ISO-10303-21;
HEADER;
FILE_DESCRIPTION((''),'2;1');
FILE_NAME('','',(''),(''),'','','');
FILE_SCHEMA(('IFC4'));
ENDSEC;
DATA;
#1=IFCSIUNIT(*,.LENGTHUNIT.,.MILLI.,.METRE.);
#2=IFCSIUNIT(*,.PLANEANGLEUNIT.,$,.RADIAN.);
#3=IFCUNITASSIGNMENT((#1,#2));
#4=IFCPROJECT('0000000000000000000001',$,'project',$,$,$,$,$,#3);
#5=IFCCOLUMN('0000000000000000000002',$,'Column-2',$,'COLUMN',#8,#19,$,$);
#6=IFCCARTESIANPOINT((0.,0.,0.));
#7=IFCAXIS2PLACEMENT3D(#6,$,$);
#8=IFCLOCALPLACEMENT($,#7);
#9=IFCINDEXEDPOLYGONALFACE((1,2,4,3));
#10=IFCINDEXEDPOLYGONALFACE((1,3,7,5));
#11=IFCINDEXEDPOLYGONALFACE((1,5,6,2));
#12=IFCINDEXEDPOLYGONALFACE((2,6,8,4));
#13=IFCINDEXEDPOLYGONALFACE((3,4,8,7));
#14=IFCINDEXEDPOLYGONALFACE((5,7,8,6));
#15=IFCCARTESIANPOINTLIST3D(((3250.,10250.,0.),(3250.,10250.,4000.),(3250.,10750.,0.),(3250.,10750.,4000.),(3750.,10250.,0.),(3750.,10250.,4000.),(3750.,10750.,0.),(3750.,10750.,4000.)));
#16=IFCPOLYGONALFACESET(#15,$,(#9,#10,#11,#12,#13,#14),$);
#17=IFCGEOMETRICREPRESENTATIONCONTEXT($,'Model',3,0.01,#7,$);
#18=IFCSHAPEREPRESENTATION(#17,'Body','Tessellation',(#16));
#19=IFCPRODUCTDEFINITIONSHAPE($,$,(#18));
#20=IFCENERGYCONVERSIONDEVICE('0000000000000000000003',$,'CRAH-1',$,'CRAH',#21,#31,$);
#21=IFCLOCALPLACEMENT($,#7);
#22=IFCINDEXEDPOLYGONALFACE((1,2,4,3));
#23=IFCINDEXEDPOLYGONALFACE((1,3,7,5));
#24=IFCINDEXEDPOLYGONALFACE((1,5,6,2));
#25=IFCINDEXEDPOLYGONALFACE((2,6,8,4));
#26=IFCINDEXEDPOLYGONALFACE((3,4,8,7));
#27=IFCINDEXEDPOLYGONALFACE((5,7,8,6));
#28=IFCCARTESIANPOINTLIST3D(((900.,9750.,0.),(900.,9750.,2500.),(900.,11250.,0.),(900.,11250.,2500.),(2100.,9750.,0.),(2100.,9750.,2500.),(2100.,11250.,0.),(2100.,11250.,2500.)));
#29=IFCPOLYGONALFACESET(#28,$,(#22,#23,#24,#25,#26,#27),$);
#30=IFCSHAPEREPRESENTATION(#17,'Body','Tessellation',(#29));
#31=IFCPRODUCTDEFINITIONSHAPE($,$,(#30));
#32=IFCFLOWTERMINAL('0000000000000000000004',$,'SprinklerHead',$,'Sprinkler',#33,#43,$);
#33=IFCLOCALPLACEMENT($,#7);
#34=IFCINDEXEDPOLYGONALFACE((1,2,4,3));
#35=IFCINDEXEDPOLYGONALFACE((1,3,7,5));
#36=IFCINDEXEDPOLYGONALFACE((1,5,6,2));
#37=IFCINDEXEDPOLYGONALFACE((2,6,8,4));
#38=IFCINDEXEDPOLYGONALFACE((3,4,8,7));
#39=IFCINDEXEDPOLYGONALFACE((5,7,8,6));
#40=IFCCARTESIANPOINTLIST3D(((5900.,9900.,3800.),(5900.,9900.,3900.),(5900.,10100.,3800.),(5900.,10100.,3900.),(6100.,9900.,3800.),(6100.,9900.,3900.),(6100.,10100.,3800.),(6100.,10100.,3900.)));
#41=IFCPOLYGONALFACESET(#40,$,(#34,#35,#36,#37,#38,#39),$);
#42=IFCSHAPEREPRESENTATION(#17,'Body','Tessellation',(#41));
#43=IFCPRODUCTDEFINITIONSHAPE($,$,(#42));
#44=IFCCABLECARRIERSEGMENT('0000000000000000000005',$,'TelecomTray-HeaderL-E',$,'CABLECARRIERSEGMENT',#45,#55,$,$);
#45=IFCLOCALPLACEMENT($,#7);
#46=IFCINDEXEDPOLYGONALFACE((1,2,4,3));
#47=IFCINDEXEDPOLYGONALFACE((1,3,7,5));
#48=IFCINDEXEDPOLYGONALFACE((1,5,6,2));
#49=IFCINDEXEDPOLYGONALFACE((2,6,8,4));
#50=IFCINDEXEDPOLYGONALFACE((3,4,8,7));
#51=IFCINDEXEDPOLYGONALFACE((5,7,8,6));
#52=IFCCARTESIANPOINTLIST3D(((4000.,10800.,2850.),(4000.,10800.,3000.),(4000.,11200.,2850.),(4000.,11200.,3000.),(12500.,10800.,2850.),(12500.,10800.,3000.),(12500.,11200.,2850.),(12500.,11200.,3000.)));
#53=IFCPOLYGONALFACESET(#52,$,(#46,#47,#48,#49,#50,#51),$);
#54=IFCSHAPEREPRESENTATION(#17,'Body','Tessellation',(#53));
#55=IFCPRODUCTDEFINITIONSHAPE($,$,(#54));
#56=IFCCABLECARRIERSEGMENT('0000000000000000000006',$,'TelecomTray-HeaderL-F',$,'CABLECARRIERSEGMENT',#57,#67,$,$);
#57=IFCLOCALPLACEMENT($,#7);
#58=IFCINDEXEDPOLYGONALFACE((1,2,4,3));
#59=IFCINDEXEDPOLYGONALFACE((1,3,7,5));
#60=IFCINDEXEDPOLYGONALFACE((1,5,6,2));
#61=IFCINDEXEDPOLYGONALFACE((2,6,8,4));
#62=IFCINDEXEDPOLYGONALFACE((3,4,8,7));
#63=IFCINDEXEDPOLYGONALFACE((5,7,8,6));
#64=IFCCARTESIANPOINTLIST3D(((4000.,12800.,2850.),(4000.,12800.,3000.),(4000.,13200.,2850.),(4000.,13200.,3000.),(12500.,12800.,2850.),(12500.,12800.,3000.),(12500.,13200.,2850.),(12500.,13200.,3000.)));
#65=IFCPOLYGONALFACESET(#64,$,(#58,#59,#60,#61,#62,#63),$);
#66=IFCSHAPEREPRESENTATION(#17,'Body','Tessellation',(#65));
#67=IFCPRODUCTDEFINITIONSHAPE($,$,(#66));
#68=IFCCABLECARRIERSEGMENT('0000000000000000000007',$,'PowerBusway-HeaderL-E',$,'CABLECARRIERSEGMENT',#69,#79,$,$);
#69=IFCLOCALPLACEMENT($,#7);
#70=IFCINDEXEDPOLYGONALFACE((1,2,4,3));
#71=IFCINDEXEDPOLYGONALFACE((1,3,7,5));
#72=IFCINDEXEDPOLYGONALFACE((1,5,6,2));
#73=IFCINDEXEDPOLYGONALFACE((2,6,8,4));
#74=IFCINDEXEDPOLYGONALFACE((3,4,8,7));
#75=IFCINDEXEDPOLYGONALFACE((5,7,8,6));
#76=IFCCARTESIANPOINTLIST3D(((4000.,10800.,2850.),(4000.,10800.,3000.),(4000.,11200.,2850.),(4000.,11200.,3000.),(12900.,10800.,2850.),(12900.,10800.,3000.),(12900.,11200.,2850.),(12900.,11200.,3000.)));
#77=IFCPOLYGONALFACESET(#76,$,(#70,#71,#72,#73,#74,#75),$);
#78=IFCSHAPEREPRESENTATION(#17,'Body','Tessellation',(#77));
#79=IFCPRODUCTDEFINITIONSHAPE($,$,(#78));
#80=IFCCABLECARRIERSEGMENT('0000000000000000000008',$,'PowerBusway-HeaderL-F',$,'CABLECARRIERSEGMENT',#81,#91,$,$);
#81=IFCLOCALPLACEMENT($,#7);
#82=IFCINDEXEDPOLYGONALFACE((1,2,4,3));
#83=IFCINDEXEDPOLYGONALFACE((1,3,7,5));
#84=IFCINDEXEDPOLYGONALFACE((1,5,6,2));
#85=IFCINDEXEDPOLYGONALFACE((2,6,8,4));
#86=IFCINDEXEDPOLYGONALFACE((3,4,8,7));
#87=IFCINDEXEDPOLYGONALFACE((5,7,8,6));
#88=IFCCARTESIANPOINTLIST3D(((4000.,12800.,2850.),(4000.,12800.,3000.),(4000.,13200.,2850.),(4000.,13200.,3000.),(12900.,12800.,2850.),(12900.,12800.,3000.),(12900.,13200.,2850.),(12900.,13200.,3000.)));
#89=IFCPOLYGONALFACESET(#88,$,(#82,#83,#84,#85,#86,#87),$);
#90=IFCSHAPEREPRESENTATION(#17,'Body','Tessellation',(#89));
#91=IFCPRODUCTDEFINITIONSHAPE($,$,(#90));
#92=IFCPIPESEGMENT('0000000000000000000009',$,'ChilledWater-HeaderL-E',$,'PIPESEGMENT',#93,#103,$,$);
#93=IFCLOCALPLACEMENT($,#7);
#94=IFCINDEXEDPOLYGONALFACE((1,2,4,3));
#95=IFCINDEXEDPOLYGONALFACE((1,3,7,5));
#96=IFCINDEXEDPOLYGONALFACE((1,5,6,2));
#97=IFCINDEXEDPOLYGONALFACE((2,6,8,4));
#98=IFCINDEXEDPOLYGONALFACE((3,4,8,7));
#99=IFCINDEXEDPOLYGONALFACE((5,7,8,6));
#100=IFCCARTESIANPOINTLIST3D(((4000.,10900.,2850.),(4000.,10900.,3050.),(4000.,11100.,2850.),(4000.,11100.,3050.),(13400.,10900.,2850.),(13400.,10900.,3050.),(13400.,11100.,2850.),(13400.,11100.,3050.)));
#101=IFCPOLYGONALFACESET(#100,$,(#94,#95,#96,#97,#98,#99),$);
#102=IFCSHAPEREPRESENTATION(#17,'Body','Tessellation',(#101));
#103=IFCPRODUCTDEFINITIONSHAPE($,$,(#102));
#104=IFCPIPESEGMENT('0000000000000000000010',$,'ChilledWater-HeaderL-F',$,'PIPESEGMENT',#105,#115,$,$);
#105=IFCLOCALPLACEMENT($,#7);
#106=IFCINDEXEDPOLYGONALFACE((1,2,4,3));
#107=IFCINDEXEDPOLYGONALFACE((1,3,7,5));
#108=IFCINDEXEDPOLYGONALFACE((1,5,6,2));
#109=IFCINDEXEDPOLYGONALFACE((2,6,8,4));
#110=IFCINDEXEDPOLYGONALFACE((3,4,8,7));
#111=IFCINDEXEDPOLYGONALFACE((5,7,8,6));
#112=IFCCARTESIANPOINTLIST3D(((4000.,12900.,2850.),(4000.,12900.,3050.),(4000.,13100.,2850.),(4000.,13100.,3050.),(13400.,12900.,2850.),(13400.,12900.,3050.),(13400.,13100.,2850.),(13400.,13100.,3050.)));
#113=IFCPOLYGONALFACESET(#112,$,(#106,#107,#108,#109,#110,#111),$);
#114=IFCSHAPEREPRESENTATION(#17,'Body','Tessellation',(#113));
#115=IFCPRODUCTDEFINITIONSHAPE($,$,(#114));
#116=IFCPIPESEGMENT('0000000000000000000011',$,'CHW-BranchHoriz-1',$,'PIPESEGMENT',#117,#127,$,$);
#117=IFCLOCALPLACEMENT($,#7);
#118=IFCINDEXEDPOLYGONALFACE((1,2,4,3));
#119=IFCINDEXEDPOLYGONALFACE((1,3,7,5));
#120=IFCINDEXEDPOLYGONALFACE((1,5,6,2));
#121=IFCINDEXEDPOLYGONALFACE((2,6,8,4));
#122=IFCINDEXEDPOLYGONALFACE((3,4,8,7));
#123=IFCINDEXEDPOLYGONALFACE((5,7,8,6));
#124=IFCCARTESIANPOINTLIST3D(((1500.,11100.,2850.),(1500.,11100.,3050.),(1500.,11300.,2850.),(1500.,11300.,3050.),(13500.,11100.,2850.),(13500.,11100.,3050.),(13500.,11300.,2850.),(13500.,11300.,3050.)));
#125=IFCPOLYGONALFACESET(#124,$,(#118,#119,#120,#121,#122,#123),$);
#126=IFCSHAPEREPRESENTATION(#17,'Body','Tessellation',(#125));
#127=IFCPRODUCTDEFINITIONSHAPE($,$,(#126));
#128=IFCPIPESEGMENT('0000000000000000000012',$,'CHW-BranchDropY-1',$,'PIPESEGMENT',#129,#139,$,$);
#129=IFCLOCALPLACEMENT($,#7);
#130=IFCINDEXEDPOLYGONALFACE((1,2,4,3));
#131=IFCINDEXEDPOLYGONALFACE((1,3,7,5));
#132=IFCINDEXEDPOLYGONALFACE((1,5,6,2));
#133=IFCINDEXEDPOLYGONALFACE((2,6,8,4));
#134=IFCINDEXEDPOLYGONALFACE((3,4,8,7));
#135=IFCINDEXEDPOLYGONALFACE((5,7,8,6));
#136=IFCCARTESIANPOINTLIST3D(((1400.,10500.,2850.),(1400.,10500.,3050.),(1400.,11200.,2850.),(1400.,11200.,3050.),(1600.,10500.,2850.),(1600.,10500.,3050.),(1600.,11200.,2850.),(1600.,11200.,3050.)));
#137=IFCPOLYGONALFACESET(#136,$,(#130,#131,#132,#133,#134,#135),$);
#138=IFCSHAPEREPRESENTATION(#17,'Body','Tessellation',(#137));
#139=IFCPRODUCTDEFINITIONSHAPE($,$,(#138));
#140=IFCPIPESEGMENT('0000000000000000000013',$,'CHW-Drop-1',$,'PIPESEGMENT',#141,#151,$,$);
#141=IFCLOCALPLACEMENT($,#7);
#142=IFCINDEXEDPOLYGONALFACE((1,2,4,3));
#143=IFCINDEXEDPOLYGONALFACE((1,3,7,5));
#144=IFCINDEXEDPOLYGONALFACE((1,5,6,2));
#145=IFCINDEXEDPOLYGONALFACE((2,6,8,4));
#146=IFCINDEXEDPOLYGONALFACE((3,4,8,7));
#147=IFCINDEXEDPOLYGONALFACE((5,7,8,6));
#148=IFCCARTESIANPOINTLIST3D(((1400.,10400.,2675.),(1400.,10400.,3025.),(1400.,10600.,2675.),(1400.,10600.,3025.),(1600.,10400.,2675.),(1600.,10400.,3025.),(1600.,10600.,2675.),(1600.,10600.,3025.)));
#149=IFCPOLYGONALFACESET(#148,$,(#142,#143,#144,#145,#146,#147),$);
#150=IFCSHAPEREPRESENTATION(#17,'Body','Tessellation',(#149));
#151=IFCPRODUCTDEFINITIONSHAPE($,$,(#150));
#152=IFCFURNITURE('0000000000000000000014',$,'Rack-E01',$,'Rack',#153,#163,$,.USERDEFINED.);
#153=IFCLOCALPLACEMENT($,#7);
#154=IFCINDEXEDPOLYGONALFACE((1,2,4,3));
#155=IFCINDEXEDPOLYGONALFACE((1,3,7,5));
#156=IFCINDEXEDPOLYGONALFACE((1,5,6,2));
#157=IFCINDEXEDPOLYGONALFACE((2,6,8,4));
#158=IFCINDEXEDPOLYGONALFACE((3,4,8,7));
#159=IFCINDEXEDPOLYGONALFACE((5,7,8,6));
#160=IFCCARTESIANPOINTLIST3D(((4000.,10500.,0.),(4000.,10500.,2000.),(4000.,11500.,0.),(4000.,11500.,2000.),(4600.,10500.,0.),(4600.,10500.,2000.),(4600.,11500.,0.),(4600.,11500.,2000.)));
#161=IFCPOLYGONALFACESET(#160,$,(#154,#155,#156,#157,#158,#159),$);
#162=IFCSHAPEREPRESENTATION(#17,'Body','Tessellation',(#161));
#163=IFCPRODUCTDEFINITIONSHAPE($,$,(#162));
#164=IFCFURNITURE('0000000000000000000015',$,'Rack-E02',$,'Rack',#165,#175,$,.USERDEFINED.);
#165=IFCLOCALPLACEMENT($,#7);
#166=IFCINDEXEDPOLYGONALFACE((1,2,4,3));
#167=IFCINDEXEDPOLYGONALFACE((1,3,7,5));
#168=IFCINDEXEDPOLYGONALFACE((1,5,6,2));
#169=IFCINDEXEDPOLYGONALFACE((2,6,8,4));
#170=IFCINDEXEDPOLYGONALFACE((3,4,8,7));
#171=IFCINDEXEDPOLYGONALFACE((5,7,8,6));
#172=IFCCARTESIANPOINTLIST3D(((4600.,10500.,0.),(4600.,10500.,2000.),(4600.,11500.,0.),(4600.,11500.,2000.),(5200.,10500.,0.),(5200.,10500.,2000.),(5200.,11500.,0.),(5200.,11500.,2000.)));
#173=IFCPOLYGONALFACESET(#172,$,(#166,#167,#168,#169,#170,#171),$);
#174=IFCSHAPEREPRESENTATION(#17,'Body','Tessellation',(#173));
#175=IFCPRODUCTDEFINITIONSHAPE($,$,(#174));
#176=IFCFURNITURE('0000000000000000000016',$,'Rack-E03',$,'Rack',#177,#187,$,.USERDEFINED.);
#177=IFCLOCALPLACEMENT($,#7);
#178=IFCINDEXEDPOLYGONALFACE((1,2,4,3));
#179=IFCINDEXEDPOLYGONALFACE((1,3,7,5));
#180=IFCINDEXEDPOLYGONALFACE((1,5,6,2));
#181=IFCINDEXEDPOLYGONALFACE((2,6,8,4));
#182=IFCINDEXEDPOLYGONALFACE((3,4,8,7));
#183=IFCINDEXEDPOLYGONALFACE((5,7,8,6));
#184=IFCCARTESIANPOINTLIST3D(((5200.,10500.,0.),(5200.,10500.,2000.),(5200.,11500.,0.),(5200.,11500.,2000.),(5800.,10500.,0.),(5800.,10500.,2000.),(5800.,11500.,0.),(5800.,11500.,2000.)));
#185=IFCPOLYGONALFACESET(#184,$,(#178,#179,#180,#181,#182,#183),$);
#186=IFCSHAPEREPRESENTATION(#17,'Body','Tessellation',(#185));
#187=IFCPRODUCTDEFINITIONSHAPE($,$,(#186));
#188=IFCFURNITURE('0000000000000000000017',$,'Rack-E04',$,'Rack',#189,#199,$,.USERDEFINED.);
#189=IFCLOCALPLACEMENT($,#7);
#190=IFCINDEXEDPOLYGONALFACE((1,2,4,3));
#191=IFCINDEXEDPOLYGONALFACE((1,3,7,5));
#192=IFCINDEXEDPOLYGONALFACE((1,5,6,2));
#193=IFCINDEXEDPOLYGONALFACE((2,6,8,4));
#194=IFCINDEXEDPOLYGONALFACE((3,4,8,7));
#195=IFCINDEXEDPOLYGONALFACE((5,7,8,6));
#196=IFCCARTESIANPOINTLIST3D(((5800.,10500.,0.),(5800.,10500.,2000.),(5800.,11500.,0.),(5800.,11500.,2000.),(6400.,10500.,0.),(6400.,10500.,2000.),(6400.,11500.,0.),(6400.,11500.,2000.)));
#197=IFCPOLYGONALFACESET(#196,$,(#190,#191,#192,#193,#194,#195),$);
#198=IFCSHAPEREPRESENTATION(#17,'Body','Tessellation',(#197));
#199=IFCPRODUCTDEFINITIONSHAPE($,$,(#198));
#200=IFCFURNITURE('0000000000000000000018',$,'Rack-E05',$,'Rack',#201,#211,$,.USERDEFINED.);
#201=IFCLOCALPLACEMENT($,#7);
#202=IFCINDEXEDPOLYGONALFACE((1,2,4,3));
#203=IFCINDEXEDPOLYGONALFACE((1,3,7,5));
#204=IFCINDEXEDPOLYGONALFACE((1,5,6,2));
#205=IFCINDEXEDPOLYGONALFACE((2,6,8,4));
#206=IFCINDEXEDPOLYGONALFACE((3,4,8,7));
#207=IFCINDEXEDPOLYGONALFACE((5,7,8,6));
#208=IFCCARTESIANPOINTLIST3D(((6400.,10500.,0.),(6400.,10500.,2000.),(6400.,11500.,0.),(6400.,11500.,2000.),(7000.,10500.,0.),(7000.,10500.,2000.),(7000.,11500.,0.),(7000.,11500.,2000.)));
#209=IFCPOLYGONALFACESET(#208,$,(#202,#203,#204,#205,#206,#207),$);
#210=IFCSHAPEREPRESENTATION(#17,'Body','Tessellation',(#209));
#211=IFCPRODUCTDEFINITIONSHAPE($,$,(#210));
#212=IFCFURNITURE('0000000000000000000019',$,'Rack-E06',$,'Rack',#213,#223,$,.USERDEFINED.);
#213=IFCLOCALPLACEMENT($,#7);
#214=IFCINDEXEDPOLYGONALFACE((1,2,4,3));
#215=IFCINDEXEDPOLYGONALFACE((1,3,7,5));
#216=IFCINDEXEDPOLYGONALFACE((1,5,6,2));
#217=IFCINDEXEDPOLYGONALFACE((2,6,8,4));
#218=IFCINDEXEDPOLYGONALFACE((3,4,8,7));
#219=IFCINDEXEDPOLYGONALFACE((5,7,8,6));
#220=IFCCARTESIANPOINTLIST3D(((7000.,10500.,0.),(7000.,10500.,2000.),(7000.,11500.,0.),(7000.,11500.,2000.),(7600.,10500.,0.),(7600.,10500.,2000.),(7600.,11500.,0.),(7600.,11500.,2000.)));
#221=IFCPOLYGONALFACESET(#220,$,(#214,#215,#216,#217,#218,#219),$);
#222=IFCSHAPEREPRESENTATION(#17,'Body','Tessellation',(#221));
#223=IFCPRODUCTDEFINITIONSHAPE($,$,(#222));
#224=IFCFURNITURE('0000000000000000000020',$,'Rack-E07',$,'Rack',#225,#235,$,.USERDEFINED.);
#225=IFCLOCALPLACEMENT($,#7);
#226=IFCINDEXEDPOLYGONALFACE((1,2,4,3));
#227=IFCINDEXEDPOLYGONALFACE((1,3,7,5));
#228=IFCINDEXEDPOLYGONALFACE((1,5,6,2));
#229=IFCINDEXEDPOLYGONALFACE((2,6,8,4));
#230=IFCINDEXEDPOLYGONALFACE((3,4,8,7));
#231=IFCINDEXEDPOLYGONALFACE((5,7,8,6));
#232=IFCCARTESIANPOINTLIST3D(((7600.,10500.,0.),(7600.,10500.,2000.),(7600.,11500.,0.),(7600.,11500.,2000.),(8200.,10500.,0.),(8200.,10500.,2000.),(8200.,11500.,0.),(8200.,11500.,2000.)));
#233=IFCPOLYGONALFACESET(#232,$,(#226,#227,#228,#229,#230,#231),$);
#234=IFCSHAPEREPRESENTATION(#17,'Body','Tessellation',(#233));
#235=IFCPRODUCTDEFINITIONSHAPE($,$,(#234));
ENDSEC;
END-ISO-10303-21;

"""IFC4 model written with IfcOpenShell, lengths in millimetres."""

from ifc_helpers import new_model, si_unit, frame, origin, place, context, project, polyline, outline, extrude, element, save


model = new_model("IFC4")

# Units and contexts
model_context = context("Model", 3, precision=0.01, world=origin())
ifc_project = project(units=[si_unit("LENGTHUNIT", "METRE", prefix="MILLI"), si_unit("PLANEANGLEUNIT", "RADIAN")])

# Column
column_placement = place(None, frame((3500.0, 10500.0, 0.0)))
element("IfcColumn", 1, at=column_placement, Name="Column-2", ObjectType="COLUMN", context=model_context, shape_type="SweptSolid", body=[
    extrude(outline(polyline([(-250.0, -250.0), (250.0, -250.0), (250.0, 250.0), (-250.0, 250.0), (-250.0, -250.0)])), origin(), (0.0, 0.0, 1.0), 4000.0),
])

# Energy conversion device
energy_conversion_device_placement = place(None, frame((1500.0, 10500.0, 0.0)))
element("IfcEnergyConversionDevice", 2, at=energy_conversion_device_placement, Name="CRAH-1", ObjectType="CRAH", context=model_context, shape_type="SweptSolid", body=[
    extrude(outline(polyline([(-600.0, -750.0), (600.0, -750.0), (600.0, 750.0), (-600.0, 750.0), (-600.0, -750.0)])), origin(), (0.0, 0.0, 1.0), 2500.0),
])

# Flow terminal
flow_terminal_placement = place(None, frame((6000.0, 10000.0, 3800.0)))
element("IfcFlowTerminal", 3, at=flow_terminal_placement, Name="SprinklerHead", ObjectType="Sprinkler", context=model_context, shape_type="SweptSolid", body=[
    extrude(outline(polyline([(-100.0, -100.0), (100.0, -100.0), (100.0, 100.0), (-100.0, 100.0), (-100.0, -100.0)])), origin(), (0.0, 0.0, 1.0), 100.0),
])

# Cable carrier segments
for number, where, name in (
    (4, (8250.0, 11000.0, 2850.0), "TelecomTray-HeaderL-E"),
    (5, (8250.0, 13000.0, 2850.0), "TelecomTray-HeaderL-F"),
):
    element("IfcCableCarrierSegment", number, at=place(None, frame(where)), Name=name, ObjectType="CABLECARRIERSEGMENT", context=model_context, shape_type="SweptSolid", body=[
        extrude(outline(polyline([(-4250.0, -200.0), (4250.0, -200.0), (4250.0, 200.0), (-4250.0, 200.0), (-4250.0, -200.0)])), origin(), (0.0, 0.0, 1.0), 150.0),
    ])
for number, where, name in (
    (6, (8450.0, 11000.0, 2850.0), "PowerBusway-HeaderL-E"),
    (7, (8450.0, 13000.0, 2850.0), "PowerBusway-HeaderL-F"),
):
    element("IfcCableCarrierSegment", number, at=place(None, frame(where)), Name=name, ObjectType="CABLECARRIERSEGMENT", context=model_context, shape_type="SweptSolid", body=[
        extrude(outline(polyline([(-4450.0, -200.0), (4450.0, -200.0), (4450.0, 200.0), (-4450.0, 200.0), (-4450.0, -200.0)])), origin(), (0.0, 0.0, 1.0), 150.0),
    ])

# Pipe segments
for number, where, name in (
    (8, (8700.0, 11000.0, 2850.0), "ChilledWater-HeaderL-E"),
    (9, (8700.0, 13000.0, 2850.0), "ChilledWater-HeaderL-F"),
):
    element("IfcPipeSegment", number, at=place(None, frame(where)), Name=name, ObjectType="PIPESEGMENT", context=model_context, shape_type="SweptSolid", body=[
        extrude(outline(polyline([(-4700.0, -100.0), (4700.0, -100.0), (4700.0, 100.0), (-4700.0, 100.0), (-4700.0, -100.0)])), origin(), (0.0, 0.0, 1.0), 200.0),
    ])
pipe_segment_1_placement = place(None, frame((7500.0, 11200.0, 2850.0)))
element("IfcPipeSegment", 10, at=pipe_segment_1_placement, Name="CHW-BranchHoriz-1", ObjectType="PIPESEGMENT", context=model_context, shape_type="SweptSolid", body=[
    extrude(outline(polyline([(-6000.0, -100.0), (6000.0, -100.0), (6000.0, 100.0), (-6000.0, 100.0), (-6000.0, -100.0)])), origin(), (0.0, 0.0, 1.0), 200.0),
])
pipe_segment_2_placement = place(None, frame((1500.0, 10850.0, 2850.0)))
element("IfcPipeSegment", 11, at=pipe_segment_2_placement, Name="CHW-BranchDropY-1", ObjectType="PIPESEGMENT", context=model_context, shape_type="SweptSolid", body=[
    extrude(outline(polyline([(-100.0, -350.0), (100.0, -350.0), (100.0, 350.0), (-100.0, 350.0), (-100.0, -350.0)])), origin(), (0.0, 0.0, 1.0), 200.0),
])
pipe_segment_3_placement = place(None, frame((1500.0, 10500.0, 2675.0)))
element("IfcPipeSegment", 12, at=pipe_segment_3_placement, Name="CHW-Drop-1", ObjectType="PIPESEGMENT", context=model_context, shape_type="SweptSolid", body=[
    extrude(outline(polyline([(-100.0, -100.0), (100.0, -100.0), (100.0, 100.0), (-100.0, 100.0), (-100.0, -100.0)])), origin(), (0.0, 0.0, 1.0), 350.0),
])

# Furniture
for number, where, name in (
    (13, (4300.0, 11000.0, 0.0), "Rack-E01"),
    (14, (4900.0, 11000.0, 0.0), "Rack-E02"),
    (15, (5500.0, 11000.0, 0.0), "Rack-E03"),
    (16, (6100.0, 11000.0, 0.0), "Rack-E04"),
    (17, (6700.0, 11000.0, 0.0), "Rack-E05"),
    (18, (7300.0, 11000.0, 0.0), "Rack-E06"),
    (19, (7900.0, 11000.0, 0.0), "Rack-E07"),
):
    element("IfcFurniture", number, at=place(None, frame(where)), Name=name, ObjectType="Rack", PredefinedType="USERDEFINED", context=model_context, shape_type="SweptSolid", body=[
        extrude(outline(polyline([(-300.0, -500.0), (300.0, -500.0), (300.0, 500.0), (-300.0, 500.0), (-300.0, -500.0)])), origin(), (0.0, 0.0, 1.0), 2000.0),
    ])

save(model, "model.ifc")
